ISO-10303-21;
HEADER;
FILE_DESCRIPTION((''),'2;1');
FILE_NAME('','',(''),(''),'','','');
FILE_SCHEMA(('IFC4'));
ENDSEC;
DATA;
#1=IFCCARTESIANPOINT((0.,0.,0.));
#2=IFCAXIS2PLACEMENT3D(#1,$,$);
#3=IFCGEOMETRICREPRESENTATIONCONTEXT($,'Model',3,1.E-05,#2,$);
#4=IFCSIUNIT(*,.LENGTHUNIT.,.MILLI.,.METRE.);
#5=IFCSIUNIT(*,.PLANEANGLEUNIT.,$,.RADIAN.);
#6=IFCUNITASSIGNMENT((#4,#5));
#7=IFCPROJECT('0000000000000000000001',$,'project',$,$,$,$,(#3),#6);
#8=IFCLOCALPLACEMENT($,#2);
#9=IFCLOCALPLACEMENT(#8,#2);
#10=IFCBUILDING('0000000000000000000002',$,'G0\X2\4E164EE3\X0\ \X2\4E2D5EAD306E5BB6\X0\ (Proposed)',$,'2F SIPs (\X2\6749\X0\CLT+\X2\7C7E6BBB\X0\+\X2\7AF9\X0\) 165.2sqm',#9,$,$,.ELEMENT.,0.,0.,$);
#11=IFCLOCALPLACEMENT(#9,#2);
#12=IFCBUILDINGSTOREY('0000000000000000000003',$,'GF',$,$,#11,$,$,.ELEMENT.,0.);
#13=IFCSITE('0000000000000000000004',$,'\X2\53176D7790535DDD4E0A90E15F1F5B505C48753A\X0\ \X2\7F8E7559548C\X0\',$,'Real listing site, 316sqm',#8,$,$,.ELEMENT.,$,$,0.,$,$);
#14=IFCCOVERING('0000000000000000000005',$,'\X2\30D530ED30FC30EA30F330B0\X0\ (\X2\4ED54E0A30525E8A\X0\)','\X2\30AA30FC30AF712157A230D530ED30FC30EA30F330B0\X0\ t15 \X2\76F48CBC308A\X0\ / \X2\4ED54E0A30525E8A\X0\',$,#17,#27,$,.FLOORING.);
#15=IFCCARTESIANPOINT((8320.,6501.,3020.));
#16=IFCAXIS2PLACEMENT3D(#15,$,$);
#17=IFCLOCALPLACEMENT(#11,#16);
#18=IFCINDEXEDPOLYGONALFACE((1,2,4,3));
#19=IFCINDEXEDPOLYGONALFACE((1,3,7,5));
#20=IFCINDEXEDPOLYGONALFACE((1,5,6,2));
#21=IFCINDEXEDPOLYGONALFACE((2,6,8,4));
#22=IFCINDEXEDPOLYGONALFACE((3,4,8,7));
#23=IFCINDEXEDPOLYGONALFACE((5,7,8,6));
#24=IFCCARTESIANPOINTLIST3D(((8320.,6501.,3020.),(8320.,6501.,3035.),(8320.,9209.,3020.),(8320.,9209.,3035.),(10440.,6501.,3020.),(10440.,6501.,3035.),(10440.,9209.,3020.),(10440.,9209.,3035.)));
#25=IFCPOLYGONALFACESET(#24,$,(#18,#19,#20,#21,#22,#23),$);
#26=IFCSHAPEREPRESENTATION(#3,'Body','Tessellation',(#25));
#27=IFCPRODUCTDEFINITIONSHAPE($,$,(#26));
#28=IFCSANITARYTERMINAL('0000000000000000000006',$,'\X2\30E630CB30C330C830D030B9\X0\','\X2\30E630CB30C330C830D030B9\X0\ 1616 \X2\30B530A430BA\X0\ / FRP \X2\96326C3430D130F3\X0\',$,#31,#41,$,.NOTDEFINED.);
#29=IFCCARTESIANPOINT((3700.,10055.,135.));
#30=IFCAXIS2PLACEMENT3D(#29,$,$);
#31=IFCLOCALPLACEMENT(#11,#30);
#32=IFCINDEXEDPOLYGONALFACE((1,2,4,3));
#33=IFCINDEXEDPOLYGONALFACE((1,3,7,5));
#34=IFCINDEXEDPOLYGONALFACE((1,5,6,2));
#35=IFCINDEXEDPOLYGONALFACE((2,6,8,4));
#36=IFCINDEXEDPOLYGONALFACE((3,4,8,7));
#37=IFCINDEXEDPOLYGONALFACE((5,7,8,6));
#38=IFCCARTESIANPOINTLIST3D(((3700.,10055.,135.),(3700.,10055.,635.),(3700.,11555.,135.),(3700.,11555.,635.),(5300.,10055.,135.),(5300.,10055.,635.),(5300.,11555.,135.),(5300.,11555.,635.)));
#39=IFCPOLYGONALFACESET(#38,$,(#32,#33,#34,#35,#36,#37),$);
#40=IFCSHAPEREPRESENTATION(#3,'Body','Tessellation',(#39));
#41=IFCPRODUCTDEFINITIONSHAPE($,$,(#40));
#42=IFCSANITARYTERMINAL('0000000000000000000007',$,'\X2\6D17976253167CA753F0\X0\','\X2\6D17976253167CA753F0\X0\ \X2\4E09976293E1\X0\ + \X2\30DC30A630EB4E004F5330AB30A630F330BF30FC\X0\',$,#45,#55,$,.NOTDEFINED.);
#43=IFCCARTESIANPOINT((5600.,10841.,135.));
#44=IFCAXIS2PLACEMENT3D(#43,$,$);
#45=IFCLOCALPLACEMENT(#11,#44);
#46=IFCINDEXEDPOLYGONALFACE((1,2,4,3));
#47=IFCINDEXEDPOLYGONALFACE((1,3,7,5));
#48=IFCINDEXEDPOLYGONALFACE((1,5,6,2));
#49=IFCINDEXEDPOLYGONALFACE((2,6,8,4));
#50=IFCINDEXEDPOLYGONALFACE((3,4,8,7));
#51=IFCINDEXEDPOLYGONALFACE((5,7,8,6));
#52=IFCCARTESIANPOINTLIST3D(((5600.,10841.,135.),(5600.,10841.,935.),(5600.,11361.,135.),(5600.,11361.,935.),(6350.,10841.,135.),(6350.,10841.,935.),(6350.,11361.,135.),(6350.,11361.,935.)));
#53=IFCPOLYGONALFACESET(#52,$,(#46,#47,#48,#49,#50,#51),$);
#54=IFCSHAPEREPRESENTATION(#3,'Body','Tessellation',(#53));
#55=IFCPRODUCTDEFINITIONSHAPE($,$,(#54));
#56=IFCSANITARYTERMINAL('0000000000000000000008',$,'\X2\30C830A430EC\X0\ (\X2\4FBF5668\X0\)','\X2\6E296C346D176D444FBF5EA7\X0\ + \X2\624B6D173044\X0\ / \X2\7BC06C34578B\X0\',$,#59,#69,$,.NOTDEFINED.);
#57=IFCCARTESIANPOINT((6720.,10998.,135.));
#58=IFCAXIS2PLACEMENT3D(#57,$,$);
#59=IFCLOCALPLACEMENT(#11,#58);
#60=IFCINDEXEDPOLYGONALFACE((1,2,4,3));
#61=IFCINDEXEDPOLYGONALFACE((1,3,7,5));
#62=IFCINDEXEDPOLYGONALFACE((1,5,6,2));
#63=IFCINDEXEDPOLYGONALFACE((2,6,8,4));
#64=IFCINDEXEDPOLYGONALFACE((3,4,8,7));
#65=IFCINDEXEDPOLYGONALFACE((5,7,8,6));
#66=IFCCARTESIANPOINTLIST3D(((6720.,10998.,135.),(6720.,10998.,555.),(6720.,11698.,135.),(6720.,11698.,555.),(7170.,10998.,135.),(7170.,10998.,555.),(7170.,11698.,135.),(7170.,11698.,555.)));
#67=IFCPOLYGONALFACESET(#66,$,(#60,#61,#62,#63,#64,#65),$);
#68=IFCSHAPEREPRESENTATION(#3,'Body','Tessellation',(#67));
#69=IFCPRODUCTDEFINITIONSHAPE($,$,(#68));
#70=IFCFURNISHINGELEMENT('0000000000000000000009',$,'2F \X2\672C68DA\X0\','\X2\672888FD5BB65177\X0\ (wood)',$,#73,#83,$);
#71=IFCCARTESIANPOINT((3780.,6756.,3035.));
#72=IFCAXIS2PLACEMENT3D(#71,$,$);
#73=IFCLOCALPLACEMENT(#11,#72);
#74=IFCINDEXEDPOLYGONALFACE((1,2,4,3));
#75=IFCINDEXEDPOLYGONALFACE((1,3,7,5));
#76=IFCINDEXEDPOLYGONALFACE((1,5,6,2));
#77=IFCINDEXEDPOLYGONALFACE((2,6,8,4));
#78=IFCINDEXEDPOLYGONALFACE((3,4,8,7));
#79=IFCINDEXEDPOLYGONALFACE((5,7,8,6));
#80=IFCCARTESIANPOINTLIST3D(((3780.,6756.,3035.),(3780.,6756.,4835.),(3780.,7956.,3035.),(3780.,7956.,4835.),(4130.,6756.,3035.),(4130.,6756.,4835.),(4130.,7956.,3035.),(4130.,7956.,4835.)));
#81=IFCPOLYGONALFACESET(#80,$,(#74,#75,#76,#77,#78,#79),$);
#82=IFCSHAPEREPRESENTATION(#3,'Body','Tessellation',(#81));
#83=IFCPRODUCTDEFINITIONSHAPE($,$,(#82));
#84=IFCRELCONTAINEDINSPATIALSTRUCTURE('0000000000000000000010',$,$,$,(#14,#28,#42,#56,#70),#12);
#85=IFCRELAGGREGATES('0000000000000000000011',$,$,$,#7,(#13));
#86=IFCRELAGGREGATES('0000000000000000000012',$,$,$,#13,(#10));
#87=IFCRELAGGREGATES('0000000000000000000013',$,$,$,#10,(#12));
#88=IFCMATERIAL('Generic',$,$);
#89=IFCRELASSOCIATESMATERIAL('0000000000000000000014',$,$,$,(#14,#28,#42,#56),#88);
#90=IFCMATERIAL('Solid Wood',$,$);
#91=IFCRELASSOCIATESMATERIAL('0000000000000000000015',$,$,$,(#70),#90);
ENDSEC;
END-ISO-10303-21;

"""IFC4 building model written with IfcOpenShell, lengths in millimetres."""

from ifc_helpers import new_model, si_unit, frame, frame_2d, origin, place, context, project, spatial, rectangle, extrude, material, element, save


model = new_model("IFC4")

# Units and contexts
model_context = context("Model", 3, precision=1e-05, world=origin())
ifc_project = project(units=[si_unit("LENGTHUNIT", "METRE", prefix="MILLI"), si_unit("PLANEANGLEUNIT", "RADIAN")], contexts=[model_context])

# Site, building, storey
site_placement = place(None, origin())
site = spatial("IfcSite", under=ifc_project, at=site_placement, Name="北海道川上郡弟子屈町 美留和", ObjectType="Real listing site, 316sqm", CompositionType="ELEMENT", RefElevation=0.0)
building_placement = place(site_placement, origin())
building = spatial("IfcBuilding", under=site, at=building_placement, Name="G0世代 中庭の家 (Proposed)", ObjectType="2F SIPs (杉CLT+籾殻+竹) 165.2sqm", CompositionType="ELEMENT", ElevationOfRefHeight=0.0, ElevationOfTerrain=0.0)
storey_placement = place(building_placement, origin())
storey = spatial("IfcBuildingStorey", under=building, at=storey_placement, Name="GF", CompositionType="ELEMENT", Elevation=0.0)

# Shared definitions
ifc_material_1 = material(Name="Solid Wood")
ifc_material_2 = material(Name="Generic")

# Covering
covering_1_placement = place(storey_placement, frame((8320.0, 6501.0, 3020.0)))
element("IfcCovering", 1, at=covering_1_placement, inside=storey, material=ifc_material_2, Name="フローリング (仕上げ床)", Description="オーク無垢フローリング t15 直貼り / 仕上げ床", PredefinedType="FLOORING", context=model_context, shape_type="SweptSolid", body=[
    extrude(rectangle(XDim=2120.0, YDim=2708.0, at=frame_2d((1060.0, 1354.0))), frame((8320.0, 6501.0, 3020.0)), (0.0, 0.0, 1.0), 15.0),
])

# Sanitary terminals
sanitary_terminal_1_placement = place(storey_placement, frame((3700.0, 10055.0, 135.0)))
element("IfcSanitaryTerminal", 2, at=sanitary_terminal_1_placement, inside=storey, material=ifc_material_2, Name="ユニットバス", Description="ユニットバス 1616 サイズ / FRP 防水パン", PredefinedType="NOTDEFINED", context=model_context, shape_type="SweptSolid", body=[
    extrude(rectangle(XDim=1600.0, YDim=1500.0, at=frame_2d((800.0, 750.0))), frame((3700.0, 10055.0, 135.0)), (0.0, 0.0, 1.0), 500.0),
])
sanitary_terminal_2_placement = place(storey_placement, frame((5600.0, 10841.0, 135.0)))
element("IfcSanitaryTerminal", 3, at=sanitary_terminal_2_placement, inside=storey, material=ifc_material_2, Name="洗面化粧台", Description="洗面化粧台 三面鏡 + ボウル一体カウンター", PredefinedType="NOTDEFINED", context=model_context, shape_type="SweptSolid", body=[
    extrude(rectangle(XDim=750.0, YDim=520.0, at=frame_2d((375.0, 260.0))), frame((5600.0, 10841.0, 135.0)), (0.0, 0.0, 1.0), 800.0),
])
sanitary_terminal_3_placement = place(storey_placement, frame((6720.0, 10998.0, 135.0)))
element("IfcSanitaryTerminal", 4, at=sanitary_terminal_3_placement, inside=storey, material=ifc_material_2, Name="トイレ (便器)", Description="温水洗浄便座 + 手洗い / 節水型", PredefinedType="NOTDEFINED", context=model_context, shape_type="SweptSolid", body=[
    extrude(rectangle(XDim=450.0, YDim=700.0, at=frame_2d((225.0, 350.0))), frame((6720.0, 10998.0, 135.0)), (0.0, 0.0, 1.0), 420.0),
])

# Furnishing element
furnishing_placement = place(storey_placement, frame((3780.0, 6756.0, 3035.0)))
element("IfcFurnishingElement", 5, at=furnishing_placement, inside=storey, material=ifc_material_1, Name="2F 本棚", Description="木製家具 (wood)", context=model_context, shape_type="SweptSolid", body=[
    extrude(rectangle(XDim=350.0, YDim=1200.0, at=frame_2d((175.0, 600.0))), frame((3780.0, 6756.0, 3035.0)), (0.0, 0.0, 1.0), 1800.0),
])

save(model, "model.ifc")
